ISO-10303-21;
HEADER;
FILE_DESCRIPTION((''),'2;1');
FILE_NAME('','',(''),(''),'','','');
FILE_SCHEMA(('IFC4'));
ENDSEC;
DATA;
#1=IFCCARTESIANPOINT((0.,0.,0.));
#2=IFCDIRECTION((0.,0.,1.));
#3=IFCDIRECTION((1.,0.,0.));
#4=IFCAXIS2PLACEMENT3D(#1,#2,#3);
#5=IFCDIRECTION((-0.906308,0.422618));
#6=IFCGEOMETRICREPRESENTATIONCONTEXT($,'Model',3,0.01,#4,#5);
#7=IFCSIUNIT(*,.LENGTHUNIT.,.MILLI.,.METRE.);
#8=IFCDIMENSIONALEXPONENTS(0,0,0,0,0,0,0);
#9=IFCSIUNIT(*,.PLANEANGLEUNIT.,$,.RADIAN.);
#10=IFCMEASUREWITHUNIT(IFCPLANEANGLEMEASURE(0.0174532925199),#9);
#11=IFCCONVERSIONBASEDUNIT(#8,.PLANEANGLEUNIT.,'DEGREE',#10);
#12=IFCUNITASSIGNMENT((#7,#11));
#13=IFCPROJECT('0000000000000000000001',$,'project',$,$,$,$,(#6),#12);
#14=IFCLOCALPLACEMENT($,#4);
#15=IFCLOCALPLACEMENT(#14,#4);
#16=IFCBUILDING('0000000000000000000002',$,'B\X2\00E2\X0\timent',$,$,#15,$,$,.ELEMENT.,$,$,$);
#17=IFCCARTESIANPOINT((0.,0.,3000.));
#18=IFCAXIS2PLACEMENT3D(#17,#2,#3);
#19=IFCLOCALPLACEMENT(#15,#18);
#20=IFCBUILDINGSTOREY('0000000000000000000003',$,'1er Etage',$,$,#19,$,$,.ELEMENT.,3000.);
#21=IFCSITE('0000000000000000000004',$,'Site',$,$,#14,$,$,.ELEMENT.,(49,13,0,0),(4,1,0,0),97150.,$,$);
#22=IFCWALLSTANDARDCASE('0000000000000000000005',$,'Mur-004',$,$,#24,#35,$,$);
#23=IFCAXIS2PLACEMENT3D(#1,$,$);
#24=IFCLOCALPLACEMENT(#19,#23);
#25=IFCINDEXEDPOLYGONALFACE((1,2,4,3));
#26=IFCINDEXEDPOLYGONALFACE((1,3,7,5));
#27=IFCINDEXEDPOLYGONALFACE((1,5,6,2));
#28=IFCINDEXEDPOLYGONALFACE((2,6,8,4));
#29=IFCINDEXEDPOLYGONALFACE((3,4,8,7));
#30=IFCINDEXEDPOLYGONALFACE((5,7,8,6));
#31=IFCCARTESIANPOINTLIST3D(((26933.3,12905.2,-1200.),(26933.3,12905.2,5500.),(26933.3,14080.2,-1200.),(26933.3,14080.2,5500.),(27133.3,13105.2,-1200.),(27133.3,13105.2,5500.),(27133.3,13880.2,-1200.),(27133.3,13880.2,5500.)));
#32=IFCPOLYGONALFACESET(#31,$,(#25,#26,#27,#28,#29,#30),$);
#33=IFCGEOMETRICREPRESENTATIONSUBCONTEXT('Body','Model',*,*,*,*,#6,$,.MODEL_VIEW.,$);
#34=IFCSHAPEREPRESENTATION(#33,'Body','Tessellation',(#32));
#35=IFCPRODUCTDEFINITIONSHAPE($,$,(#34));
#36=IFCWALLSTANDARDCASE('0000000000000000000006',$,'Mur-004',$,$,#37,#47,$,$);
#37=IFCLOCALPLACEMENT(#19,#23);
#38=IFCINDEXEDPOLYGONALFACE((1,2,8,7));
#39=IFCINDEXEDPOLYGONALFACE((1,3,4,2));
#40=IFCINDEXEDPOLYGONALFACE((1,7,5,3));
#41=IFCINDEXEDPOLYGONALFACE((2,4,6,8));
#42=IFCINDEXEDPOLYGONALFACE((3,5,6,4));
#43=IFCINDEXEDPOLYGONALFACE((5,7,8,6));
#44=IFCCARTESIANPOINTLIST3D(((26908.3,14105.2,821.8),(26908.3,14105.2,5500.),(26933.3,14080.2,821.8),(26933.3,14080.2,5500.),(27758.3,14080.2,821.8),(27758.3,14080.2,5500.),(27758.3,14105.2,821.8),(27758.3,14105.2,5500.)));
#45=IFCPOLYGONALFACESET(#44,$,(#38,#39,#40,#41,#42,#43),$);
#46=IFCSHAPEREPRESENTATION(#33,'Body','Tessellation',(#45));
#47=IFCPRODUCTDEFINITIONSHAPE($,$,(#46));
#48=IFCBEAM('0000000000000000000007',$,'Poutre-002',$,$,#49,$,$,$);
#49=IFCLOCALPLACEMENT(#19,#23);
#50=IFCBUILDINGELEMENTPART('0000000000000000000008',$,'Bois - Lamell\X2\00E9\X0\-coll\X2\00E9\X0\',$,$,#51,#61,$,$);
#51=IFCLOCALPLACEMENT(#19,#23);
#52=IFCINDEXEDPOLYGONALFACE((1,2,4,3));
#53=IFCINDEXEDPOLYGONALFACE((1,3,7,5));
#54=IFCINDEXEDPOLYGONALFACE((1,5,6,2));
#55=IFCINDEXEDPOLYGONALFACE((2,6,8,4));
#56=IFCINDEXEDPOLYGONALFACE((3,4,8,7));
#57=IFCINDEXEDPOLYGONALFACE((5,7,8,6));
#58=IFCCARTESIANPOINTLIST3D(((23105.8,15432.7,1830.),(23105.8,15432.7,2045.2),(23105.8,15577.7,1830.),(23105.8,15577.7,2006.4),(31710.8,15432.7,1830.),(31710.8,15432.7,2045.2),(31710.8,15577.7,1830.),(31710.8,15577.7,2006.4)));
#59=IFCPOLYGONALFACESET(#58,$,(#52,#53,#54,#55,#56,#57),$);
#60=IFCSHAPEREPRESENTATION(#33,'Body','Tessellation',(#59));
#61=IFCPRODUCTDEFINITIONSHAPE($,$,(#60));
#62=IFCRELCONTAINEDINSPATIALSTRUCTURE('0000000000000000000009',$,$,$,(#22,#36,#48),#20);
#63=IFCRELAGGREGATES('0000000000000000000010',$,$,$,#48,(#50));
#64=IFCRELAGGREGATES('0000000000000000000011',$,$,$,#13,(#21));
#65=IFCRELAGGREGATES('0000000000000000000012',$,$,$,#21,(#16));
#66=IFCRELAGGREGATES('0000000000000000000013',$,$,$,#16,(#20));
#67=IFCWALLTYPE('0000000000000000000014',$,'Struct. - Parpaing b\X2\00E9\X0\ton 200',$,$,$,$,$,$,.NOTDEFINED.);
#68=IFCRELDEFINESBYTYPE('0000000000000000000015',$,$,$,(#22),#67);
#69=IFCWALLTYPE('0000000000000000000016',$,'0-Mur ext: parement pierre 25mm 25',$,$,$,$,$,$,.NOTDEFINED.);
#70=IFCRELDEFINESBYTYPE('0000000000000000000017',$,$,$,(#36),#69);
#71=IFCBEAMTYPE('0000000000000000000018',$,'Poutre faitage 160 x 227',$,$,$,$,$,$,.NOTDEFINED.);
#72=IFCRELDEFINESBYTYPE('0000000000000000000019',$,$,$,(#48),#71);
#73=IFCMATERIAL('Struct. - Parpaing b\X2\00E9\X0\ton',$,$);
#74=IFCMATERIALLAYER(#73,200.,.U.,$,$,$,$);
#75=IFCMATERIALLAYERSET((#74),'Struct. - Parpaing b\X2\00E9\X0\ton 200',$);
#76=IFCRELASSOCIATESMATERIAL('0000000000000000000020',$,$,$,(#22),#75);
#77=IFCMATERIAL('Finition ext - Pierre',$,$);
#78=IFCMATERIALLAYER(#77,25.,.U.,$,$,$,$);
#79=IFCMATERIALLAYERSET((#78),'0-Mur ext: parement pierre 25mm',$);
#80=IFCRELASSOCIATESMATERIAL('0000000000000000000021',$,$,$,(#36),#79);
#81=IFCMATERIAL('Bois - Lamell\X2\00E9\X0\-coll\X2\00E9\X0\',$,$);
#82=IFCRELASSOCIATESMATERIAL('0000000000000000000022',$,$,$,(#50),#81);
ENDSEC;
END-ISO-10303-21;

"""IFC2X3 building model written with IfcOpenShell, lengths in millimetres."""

from ifc_helpers import new_model, entity, si_unit, converted_unit, direction, frame, origin_with_axes, place, context, subcontext, project, spatial, polyline, outline, extrude, material, layer, layer_set, layer_usage, type_object, element, aggregate, save


model = new_model("IFC2X3")

# Units and contexts
model_context = context("Model", 3, precision=0.01, world=origin_with_axes(), true_north=direction((-0.906308, 0.422618)))
body_context = subcontext(model_context, "Body", "Model", "MODEL_VIEW")
ifc_project = project(units=[si_unit("LENGTHUNIT", "METRE", prefix="MILLI"), converted_unit("PLANEANGLEUNIT", "DEGREE", entity("IfcPlaneAngleMeasure", 0.0174532925199), si_unit("PLANEANGLEUNIT", "RADIAN"), dimensions=[0, 0, 0, 0, 0, 0, 0])], contexts=[model_context])

# Site, building, storey
site_placement = place(None, origin_with_axes())
site = spatial("IfcSite", under=ifc_project, at=site_placement, Name="Site", CompositionType="ELEMENT", RefLatitude=(49, 13, 0, 0), RefLongitude=(4, 1, 0, 0), RefElevation=97150.0)
building_placement = place(site_placement, origin_with_axes())
building = spatial("IfcBuilding", under=site, at=building_placement, Name="Bâtiment", CompositionType="ELEMENT")
storey_placement = place(building_placement, frame((0.0, 0.0, 3000.0), z_axis=(0.0, 0.0, 1.0), x_axis=(1.0, 0.0, 0.0)))
storey = spatial("IfcBuildingStorey", under=building, at=storey_placement, Name="1er Etage", CompositionType="ELEMENT", Elevation=3000.0)

# Shared definitions
ifc_material_1 = material(Name="Bois - Lamellé-collé")

# Walls
ifc_material_2 = material(Name="Struct. - Parpaing béton")
ifc_layer_1 = layer(ifc_material_2, 200.0, ventilated="UNKNOWN")
ifc_layer_set_1 = layer_set([ifc_layer_1], Name="Struct. - Parpaing béton 200")
wall_type_1 = type_object("IfcWallType", Name="Struct. - Parpaing béton 200", PredefinedType="NOTDEFINED")
ifc_layer_usage_1 = layer_usage(ifc_layer_set_1, "AXIS2", "NEGATIVE", 100.0)
wall_1_placement = place(storey_placement, frame((27033.3, 13005.2, -1200.0), z_axis=(0.0, 0.0, 1.0), x_axis=(0.0, 1.0, 0.0)))
element("IfcWallStandardCase", 1, at=wall_1_placement, inside=storey, type_object=wall_type_1, material=ifc_layer_usage_1, Name="Mur-004", context=body_context, shape_type="SweptSolid", body=[
    extrude(outline(polyline([(100.0, -100.0), (875.0, -100.0), (1075.0, 100.0), (-100.0, 100.0), (100.0, -100.0)])), origin_with_axes(), (0.0, 0.0, 1.0), 6700.0),
])
ifc_material_3 = material(Name="Finition ext - Pierre")
ifc_layer_2 = layer(ifc_material_3, 25.0, ventilated="UNKNOWN")
ifc_layer_set_2 = layer_set([ifc_layer_2], Name="0-Mur ext: parement pierre 25mm")
wall_type_2 = type_object("IfcWallType", Name="0-Mur ext: parement pierre 25mm 25", PredefinedType="NOTDEFINED")
ifc_layer_usage_2 = layer_usage(ifc_layer_set_2, "AXIS2", "POSITIVE", -25.0)
wall_2_placement = place(storey_placement, frame((26933.3, 14105.2, 821.8), z_axis=(0.0, 0.0, 1.0), x_axis=(1.0, 0.0, 0.0)))
element("IfcWallStandardCase", 2, at=wall_2_placement, inside=storey, type_object=wall_type_2, material=ifc_layer_usage_2, Name="Mur-004", context=body_context, shape_type="SweptSolid", body=[
    extrude(outline(polyline([(0.0, -25.0), (825.0, -25.0), (825.0, 0.0), (-25.0, 0.0), (0.0, -25.0)])), origin_with_axes(), (0.0, 0.0, 1.0), 4678.2),
])

# Beam, building element part
beam_type_1 = type_object("IfcBeamType", Name="Poutre faitage 160 x 227", PredefinedType="NOTDEFINED")
beam_1_placement = place(storey_placement, frame((23105.8, 15505.2, 1830.0), z_axis=(0.0, 0.0, 1.0), x_axis=(0.0, -1.0, 0.0)))
beam_1 = element("IfcBeam", 3, at=beam_1_placement, inside=storey, type_object=beam_type_1, Name="Poutre-002")
building_element_part_1_placement = place(beam_1_placement, origin_with_axes())
building_element_part_1 = element("IfcBuildingElementPart", 4, at=building_element_part_1_placement, material=ifc_material_1, Name="Bois - Lamellé-collé", context=body_context, shape_type="SweptSolid", body=[
    extrude(outline(polyline([(-72.5, 0.0), (72.5, 0.0), (72.5, 215.2), (-72.5, 176.4), (-72.5, 0.0)])), frame((0.0, 8605.0, 0.0), z_axis=(0.0, -1.0, 0.0), x_axis=(1.0, 0.0, 0.0)), (0.0, 0.0, 1.0), 8605.0),
])
aggregate(beam_1, [building_element_part_1])

save(model, "model.ifc")
